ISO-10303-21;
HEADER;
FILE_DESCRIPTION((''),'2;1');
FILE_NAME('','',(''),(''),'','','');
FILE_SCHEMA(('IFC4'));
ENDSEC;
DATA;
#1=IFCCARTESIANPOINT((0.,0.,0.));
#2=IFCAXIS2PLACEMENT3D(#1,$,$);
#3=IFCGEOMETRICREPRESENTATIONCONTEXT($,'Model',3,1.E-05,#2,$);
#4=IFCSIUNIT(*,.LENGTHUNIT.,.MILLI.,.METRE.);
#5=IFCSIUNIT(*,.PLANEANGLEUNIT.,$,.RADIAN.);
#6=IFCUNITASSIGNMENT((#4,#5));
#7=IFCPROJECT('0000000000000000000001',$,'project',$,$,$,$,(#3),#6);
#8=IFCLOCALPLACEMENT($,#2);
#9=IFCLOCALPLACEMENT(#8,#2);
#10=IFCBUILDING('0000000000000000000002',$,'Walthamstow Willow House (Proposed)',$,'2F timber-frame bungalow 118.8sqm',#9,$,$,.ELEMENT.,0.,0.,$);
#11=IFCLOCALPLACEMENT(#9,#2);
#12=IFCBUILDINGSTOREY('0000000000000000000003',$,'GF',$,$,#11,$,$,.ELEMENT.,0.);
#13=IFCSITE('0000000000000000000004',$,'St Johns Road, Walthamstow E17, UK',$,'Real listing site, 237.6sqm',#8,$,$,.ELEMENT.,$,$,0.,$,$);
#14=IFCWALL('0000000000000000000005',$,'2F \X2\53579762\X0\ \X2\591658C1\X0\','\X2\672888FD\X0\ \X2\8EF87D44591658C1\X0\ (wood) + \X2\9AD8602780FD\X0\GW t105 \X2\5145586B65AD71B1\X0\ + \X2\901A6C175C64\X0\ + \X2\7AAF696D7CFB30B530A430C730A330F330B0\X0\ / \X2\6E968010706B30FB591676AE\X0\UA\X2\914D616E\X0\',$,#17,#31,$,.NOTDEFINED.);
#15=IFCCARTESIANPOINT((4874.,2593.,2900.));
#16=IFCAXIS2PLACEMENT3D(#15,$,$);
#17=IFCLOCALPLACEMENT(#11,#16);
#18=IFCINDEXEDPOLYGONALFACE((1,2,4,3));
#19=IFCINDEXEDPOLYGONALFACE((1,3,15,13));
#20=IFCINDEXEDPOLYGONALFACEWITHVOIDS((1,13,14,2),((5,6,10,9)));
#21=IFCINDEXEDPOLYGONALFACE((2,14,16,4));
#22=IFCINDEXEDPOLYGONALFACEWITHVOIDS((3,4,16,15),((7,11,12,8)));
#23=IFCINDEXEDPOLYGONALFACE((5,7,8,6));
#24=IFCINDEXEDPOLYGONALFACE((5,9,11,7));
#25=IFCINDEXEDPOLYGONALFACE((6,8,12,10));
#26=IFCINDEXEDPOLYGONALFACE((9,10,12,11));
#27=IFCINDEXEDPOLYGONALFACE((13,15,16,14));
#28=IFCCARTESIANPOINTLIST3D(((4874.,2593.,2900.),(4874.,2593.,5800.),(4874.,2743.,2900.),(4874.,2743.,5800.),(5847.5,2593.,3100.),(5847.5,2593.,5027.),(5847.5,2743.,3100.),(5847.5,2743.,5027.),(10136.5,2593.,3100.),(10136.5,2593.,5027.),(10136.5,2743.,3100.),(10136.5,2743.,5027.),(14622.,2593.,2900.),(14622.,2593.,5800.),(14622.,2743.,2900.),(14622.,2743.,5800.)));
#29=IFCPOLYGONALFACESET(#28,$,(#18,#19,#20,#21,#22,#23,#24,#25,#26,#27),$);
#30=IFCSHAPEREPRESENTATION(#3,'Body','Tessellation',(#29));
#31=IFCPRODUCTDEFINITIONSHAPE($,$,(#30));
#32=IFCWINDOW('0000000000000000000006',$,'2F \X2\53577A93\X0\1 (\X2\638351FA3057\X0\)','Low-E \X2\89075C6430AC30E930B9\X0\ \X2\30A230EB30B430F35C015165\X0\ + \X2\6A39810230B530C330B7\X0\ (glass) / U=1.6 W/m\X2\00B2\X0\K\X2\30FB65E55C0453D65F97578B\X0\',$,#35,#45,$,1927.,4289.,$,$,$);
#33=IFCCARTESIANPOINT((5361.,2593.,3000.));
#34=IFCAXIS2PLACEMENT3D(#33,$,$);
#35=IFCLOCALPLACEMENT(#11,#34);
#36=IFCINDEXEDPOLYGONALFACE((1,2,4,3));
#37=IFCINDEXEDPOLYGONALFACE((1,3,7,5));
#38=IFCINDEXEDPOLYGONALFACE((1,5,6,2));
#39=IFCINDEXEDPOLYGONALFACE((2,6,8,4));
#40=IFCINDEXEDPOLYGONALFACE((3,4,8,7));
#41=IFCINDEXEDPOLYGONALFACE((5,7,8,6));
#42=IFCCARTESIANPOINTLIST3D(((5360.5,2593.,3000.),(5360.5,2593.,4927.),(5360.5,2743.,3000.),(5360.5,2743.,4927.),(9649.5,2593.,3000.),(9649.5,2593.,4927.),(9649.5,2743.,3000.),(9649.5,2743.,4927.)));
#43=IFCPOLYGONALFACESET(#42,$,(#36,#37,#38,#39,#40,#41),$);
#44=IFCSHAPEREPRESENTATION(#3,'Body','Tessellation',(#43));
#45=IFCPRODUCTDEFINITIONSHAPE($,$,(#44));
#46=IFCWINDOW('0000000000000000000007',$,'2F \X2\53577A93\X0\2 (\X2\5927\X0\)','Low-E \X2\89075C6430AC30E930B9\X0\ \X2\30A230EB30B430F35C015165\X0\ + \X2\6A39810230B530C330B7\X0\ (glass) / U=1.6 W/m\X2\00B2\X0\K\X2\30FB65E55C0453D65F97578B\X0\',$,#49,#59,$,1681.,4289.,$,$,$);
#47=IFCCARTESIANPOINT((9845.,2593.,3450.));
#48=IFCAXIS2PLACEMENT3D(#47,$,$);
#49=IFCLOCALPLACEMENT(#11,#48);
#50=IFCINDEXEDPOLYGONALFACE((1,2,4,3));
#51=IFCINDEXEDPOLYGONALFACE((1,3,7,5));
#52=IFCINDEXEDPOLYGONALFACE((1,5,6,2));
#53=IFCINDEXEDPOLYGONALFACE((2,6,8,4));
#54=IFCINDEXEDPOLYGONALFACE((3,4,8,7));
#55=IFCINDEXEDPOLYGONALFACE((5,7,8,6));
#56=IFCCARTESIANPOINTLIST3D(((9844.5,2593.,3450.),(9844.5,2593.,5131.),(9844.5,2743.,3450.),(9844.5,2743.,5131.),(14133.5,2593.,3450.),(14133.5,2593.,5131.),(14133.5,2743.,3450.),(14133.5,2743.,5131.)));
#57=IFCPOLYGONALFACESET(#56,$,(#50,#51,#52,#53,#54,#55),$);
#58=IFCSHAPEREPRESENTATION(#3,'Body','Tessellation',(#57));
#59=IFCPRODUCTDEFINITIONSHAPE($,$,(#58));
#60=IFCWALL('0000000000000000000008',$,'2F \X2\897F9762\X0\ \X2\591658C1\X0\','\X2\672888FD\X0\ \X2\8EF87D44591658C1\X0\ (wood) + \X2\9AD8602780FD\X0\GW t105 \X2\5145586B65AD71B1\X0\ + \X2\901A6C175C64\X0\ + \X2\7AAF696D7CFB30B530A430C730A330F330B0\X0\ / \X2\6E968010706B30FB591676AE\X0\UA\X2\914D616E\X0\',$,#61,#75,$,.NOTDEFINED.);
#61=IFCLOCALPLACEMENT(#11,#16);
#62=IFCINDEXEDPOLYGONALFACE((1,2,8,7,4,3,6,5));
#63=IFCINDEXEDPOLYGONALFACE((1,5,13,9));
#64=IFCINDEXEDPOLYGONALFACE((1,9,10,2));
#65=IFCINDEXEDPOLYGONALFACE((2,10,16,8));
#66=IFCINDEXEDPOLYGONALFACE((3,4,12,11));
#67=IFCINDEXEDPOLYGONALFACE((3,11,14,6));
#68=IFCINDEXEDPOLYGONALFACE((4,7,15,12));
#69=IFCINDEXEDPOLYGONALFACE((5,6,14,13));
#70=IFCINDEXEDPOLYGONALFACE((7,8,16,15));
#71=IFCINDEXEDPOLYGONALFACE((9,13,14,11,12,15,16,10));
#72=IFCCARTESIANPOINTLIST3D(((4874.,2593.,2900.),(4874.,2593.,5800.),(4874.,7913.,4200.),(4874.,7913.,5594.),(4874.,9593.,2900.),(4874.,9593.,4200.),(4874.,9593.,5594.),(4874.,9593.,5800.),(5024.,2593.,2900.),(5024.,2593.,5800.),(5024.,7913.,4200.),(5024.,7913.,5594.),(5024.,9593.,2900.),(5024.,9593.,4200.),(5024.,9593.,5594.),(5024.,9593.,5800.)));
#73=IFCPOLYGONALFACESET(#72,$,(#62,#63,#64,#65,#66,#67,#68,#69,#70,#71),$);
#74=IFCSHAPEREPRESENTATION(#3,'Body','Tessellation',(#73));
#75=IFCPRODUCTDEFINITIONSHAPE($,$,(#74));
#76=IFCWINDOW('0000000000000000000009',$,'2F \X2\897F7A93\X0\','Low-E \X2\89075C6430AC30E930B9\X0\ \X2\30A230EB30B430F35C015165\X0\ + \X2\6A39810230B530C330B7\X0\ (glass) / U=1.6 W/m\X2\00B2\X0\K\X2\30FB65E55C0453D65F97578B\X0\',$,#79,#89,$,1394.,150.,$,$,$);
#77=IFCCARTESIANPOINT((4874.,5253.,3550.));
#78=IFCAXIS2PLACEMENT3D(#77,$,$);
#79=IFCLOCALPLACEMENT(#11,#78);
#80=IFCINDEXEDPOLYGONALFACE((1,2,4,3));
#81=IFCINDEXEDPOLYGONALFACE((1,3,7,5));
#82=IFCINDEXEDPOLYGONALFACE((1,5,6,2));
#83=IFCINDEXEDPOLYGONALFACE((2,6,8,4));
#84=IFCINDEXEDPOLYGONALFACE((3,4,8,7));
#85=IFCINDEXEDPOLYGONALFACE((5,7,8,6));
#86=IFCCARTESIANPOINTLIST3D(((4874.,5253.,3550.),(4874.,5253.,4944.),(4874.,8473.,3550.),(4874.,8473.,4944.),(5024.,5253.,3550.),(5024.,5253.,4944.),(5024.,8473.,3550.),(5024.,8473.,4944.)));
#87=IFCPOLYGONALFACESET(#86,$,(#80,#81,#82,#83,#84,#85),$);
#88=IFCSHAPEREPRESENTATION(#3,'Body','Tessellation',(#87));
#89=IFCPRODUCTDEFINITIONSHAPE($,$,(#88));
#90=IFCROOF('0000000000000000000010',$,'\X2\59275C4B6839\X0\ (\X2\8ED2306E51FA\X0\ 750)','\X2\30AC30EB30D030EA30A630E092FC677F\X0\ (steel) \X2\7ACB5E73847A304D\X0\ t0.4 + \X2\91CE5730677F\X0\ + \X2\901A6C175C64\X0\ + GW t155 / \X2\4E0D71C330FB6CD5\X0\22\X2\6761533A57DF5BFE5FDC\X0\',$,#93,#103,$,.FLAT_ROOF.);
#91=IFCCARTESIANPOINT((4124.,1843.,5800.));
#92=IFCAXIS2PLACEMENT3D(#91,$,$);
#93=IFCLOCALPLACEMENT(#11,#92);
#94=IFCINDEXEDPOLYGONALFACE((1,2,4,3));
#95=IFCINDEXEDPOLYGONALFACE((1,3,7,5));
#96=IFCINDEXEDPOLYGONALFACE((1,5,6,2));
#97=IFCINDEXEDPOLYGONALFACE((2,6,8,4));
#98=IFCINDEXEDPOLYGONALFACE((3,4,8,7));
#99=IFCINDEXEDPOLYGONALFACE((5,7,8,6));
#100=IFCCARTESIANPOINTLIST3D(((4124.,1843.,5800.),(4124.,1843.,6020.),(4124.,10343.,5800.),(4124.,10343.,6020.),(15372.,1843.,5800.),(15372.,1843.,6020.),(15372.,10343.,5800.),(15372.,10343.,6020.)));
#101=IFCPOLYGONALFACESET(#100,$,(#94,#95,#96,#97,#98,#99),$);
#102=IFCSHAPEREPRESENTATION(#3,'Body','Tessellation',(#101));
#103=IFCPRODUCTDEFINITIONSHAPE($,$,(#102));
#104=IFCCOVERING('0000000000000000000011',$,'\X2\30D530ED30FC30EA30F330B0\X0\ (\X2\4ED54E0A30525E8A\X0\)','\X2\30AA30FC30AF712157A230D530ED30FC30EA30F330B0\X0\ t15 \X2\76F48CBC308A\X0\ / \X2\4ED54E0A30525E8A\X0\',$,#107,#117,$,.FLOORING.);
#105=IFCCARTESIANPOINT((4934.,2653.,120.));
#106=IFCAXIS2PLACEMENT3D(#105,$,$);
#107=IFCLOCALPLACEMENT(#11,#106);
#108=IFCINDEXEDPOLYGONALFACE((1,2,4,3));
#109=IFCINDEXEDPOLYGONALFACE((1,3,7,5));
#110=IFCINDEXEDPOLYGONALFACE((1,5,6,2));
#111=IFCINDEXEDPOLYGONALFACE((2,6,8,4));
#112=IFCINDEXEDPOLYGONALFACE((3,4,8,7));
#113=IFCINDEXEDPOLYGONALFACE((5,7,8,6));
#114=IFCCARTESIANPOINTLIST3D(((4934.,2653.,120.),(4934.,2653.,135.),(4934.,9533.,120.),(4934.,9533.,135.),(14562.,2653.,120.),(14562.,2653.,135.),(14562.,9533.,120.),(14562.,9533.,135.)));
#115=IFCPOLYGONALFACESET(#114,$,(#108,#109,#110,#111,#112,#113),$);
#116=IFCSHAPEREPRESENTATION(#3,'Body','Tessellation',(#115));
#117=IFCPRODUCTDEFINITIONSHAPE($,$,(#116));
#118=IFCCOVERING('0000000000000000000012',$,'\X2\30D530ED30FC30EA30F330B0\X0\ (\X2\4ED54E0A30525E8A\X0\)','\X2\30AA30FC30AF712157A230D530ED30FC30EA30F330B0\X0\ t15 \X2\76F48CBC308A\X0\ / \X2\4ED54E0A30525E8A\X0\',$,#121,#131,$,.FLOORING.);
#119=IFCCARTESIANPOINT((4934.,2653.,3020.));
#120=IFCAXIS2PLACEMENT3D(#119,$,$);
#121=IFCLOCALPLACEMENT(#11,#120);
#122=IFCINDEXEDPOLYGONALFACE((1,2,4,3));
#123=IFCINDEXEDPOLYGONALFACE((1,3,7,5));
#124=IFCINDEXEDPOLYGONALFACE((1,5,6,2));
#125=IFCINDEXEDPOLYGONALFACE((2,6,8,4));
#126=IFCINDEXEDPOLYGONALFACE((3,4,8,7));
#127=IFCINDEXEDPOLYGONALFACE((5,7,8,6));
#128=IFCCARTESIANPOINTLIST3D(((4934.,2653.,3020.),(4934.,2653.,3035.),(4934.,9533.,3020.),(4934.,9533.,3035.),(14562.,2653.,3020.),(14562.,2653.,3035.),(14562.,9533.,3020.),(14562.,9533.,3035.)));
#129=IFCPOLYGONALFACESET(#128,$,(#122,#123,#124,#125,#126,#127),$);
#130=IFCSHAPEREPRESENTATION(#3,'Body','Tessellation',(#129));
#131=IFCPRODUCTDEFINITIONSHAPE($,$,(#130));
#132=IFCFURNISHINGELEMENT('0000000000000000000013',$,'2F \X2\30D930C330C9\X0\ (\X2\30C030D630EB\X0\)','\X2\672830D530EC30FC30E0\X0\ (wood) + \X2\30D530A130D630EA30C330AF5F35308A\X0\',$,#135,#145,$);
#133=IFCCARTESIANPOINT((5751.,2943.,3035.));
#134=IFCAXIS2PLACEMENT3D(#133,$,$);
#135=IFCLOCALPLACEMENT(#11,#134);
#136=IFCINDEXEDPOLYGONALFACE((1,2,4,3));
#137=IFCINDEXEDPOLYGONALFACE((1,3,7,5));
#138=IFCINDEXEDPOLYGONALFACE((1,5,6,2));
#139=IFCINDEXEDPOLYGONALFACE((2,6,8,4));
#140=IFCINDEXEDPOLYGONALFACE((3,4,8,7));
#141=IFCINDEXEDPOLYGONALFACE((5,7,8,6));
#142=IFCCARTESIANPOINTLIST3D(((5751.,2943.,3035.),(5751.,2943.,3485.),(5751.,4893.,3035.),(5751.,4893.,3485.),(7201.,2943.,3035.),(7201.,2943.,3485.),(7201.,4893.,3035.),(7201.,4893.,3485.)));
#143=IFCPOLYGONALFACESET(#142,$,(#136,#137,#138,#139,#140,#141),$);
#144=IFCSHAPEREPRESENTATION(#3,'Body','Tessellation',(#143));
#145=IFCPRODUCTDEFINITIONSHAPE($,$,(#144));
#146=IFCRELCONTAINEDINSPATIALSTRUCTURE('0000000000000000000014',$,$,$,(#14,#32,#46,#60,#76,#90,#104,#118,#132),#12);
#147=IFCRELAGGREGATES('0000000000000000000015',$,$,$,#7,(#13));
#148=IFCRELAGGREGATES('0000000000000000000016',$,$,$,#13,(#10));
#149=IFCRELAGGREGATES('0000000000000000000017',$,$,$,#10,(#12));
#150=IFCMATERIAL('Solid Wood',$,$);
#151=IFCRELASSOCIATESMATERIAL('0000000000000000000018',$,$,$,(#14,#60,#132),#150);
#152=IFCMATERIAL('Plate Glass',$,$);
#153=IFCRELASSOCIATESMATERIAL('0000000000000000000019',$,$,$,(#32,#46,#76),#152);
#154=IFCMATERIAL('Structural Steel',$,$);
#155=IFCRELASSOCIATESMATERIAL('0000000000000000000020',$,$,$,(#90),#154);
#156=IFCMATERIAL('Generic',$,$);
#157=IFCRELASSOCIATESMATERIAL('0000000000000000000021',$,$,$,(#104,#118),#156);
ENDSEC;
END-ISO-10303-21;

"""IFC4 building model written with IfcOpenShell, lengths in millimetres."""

from ifc_helpers import new_model, si_unit, frame, frame_2d, origin, place, context, project, spatial, rectangle, extrude, material, element, fill, save


model = new_model("IFC4")

# Units and contexts
model_context = context("Model", 3, precision=1e-05, world=origin())
ifc_project = project(units=[si_unit("LENGTHUNIT", "METRE", prefix="MILLI"), si_unit("PLANEANGLEUNIT", "RADIAN")], contexts=[model_context])

# Site, building, storey
site_placement = place(None, origin())
site = spatial("IfcSite", under=ifc_project, at=site_placement, Name="St Johns Road, Walthamstow E17, UK", ObjectType="Real listing site, 237.6sqm", CompositionType="ELEMENT", RefElevation=0.0)
building_placement = place(site_placement, origin())
building = spatial("IfcBuilding", under=site, at=building_placement, Name="Walthamstow Willow House (Proposed)", ObjectType="2F timber-frame bungalow 118.8sqm", CompositionType="ELEMENT", ElevationOfRefHeight=0.0, ElevationOfTerrain=0.0)
storey_placement = place(building_placement, origin())
storey = spatial("IfcBuildingStorey", under=building, at=storey_placement, Name="GF", CompositionType="ELEMENT", Elevation=0.0)

# Shared definitions
ifc_material_1 = material(Name="Solid Wood")

# Shared definitions
ifc_material_2 = material(Name="Plate Glass")

# Wall, openings, windows
wall_1_placement = place(storey_placement, frame((4874.0, 2593.0, 2900.0)))
wall_1 = element("IfcWall", 1, at=wall_1_placement, inside=storey, material=ifc_material_1, Name="2F 南面 外壁", Description="木製 軸組外壁 (wood) + 高性能GW t105 充填断熱 + 通気層 + 窯業系サイディング / 準耐火・外皮UA配慮", PredefinedType="NOTDEFINED", context=model_context, shape_type="SweptSolid", body=[
    extrude(rectangle(XDim=9748.0, YDim=150.0, at=frame_2d((4874.0, 75.0))), frame((4874.0, 2593.0, 2900.0)), (0.0, 0.0, 1.0), 2900.0),
])
opening_1_placement = place(storey_placement, frame((5361.0, 2593.0, 3000.0)))
opening_1 = element("IfcOpeningElement", 2, at=opening_1_placement, cuts=wall_1, PredefinedType="NOTDEFINED", context=model_context, shape_type="SweptSolid", body=[
    extrude(rectangle(XDim=4289.0, YDim=150.0, at=frame_2d((2144.0, 75.0))), frame((5361.0, 2593.0, 3000.0)), (0.0, 0.0, 1.0), 1927.0),
])
opening_2_placement = place(storey_placement, frame((9845.0, 2593.0, 3450.0)))
opening_2 = element("IfcOpeningElement", 3, at=opening_2_placement, cuts=wall_1, PredefinedType="NOTDEFINED", context=model_context, shape_type="SweptSolid", body=[
    extrude(rectangle(XDim=4289.0, YDim=150.0, at=frame_2d((2144.0, 75.0))), frame((9845.0, 2593.0, 3450.0)), (0.0, 0.0, 1.0), 1681.0),
])
window_1_placement = place(storey_placement, frame((5361.0, 2593.0, 3000.0)))
window_1 = element("IfcWindow", 4, at=window_1_placement, inside=storey, material=ifc_material_2, Name="2F 南窓1 (掃出し)", Description="Low-E 複層ガラス アルゴン封入 + 樹脂サッシ (glass) / U=1.6 W/m²K・日射取得型", OverallHeight=1927.0, OverallWidth=4289.0, context=model_context, shape_type="SweptSolid", body=[
    extrude(rectangle(XDim=4289.0, YDim=150.0, at=frame_2d((2144.0, 75.0))), frame((5361.0, 2593.0, 3000.0)), (0.0, 0.0, 1.0), 1927.0),
])
fill(opening_1, window_1)
window_2_placement = place(storey_placement, frame((9845.0, 2593.0, 3450.0)))
window_2 = element("IfcWindow", 5, at=window_2_placement, inside=storey, material=ifc_material_2, Name="2F 南窓2 (大)", Description="Low-E 複層ガラス アルゴン封入 + 樹脂サッシ (glass) / U=1.6 W/m²K・日射取得型", OverallHeight=1681.0, OverallWidth=4289.0, context=model_context, shape_type="SweptSolid", body=[
    extrude(rectangle(XDim=4289.0, YDim=150.0, at=frame_2d((2144.0, 75.0))), frame((9845.0, 2593.0, 3450.0)), (0.0, 0.0, 1.0), 1681.0),
])
fill(opening_2, window_2)

# Wall, opening, window
wall_2_placement = place(storey_placement, frame((4874.0, 2593.0, 2900.0)))
wall_2 = element("IfcWall", 6, at=wall_2_placement, inside=storey, material=ifc_material_1, Name="2F 西面 外壁", Description="木製 軸組外壁 (wood) + 高性能GW t105 充填断熱 + 通気層 + 窯業系サイディング / 準耐火・外皮UA配慮", PredefinedType="NOTDEFINED", context=model_context, shape_type="SweptSolid", body=[
    extrude(rectangle(XDim=150.0, YDim=7000.0, at=frame_2d((75.0, 3500.0))), frame((4874.0, 2593.0, 2900.0)), (0.0, 0.0, 1.0), 2900.0),
])
opening_3_placement = place(storey_placement, frame((4874.0, 5253.0, 3550.0)))
opening_3 = element("IfcOpeningElement", 7, at=opening_3_placement, cuts=wall_2, PredefinedType="NOTDEFINED", context=model_context, shape_type="SweptSolid", body=[
    extrude(rectangle(XDim=150.0, YDim=3220.0, at=frame_2d((75.0, 1610.0))), frame((4874.0, 5253.0, 3550.0)), (0.0, 0.0, 1.0), 1394.0),
])
window_3_placement = place(storey_placement, frame((4874.0, 5253.0, 3550.0)))
window_3 = element("IfcWindow", 8, at=window_3_placement, inside=storey, material=ifc_material_2, Name="2F 西窓", Description="Low-E 複層ガラス アルゴン封入 + 樹脂サッシ (glass) / U=1.6 W/m²K・日射取得型", OverallHeight=1394.0, OverallWidth=150.0, context=model_context, shape_type="SweptSolid", body=[
    extrude(rectangle(XDim=150.0, YDim=3220.0, at=frame_2d((75.0, 1610.0))), frame((4874.0, 5253.0, 3550.0)), (0.0, 0.0, 1.0), 1394.0),
])
fill(opening_3, window_3)

# Roof
ifc_material_3 = material(Name="Structural Steel")
roof_placement = place(storey_placement, frame((4124.0, 1843.0, 5800.0)))
element("IfcRoof", 9, at=roof_placement, inside=storey, material=ifc_material_3, Name="大屋根 (軒の出 750)", Description="ガルバリウム鋼板 (steel) 立平葺き t0.4 + 野地板 + 通気層 + GW t155 / 不燃・法22条区域対応", PredefinedType="FLAT_ROOF", context=model_context, shape_type="SweptSolid", body=[
    extrude(rectangle(XDim=11248.0, YDim=8500.0, at=frame_2d((5624.0, 4250.0))), frame((4124.0, 1843.0, 5800.0)), (0.0, 0.0, 1.0), 220.0),
])

# Coverings
ifc_material_4 = material(Name="Generic")
covering_1_placement = place(storey_placement, frame((4934.0, 2653.0, 120.0)))
element("IfcCovering", 10, at=covering_1_placement, inside=storey, material=ifc_material_4, Name="フローリング (仕上げ床)", Description="オーク無垢フローリング t15 直貼り / 仕上げ床", PredefinedType="FLOORING", context=model_context, shape_type="SweptSolid", body=[
    extrude(rectangle(XDim=9628.0, YDim=6880.0, at=frame_2d((4814.0, 3440.0))), frame((4934.0, 2653.0, 120.0)), (0.0, 0.0, 1.0), 15.0),
])
covering_2_placement = place(storey_placement, frame((4934.0, 2653.0, 3020.0)))
element("IfcCovering", 11, at=covering_2_placement, inside=storey, material=ifc_material_4, Name="フローリング (仕上げ床)", Description="オーク無垢フローリング t15 直貼り / 仕上げ床", PredefinedType="FLOORING", context=model_context, shape_type="SweptSolid", body=[
    extrude(rectangle(XDim=9628.0, YDim=6880.0, at=frame_2d((4814.0, 3440.0))), frame((4934.0, 2653.0, 3020.0)), (0.0, 0.0, 1.0), 15.0),
])

# Furnishing element
furnishing_placement = place(storey_placement, frame((5751.0, 2943.0, 3035.0)))
element("IfcFurnishingElement", 12, at=furnishing_placement, inside=storey, material=ifc_material_1, Name="2F ベッド (ダブル)", Description="木フレーム (wood) + ファブリック張り", context=model_context, shape_type="SweptSolid", body=[
    extrude(rectangle(XDim=1450.0, YDim=1950.0, at=frame_2d((725.0, 975.0))), frame((5751.0, 2943.0, 3035.0)), (0.0, 0.0, 1.0), 450.0),
])

save(model, "model.ifc")
